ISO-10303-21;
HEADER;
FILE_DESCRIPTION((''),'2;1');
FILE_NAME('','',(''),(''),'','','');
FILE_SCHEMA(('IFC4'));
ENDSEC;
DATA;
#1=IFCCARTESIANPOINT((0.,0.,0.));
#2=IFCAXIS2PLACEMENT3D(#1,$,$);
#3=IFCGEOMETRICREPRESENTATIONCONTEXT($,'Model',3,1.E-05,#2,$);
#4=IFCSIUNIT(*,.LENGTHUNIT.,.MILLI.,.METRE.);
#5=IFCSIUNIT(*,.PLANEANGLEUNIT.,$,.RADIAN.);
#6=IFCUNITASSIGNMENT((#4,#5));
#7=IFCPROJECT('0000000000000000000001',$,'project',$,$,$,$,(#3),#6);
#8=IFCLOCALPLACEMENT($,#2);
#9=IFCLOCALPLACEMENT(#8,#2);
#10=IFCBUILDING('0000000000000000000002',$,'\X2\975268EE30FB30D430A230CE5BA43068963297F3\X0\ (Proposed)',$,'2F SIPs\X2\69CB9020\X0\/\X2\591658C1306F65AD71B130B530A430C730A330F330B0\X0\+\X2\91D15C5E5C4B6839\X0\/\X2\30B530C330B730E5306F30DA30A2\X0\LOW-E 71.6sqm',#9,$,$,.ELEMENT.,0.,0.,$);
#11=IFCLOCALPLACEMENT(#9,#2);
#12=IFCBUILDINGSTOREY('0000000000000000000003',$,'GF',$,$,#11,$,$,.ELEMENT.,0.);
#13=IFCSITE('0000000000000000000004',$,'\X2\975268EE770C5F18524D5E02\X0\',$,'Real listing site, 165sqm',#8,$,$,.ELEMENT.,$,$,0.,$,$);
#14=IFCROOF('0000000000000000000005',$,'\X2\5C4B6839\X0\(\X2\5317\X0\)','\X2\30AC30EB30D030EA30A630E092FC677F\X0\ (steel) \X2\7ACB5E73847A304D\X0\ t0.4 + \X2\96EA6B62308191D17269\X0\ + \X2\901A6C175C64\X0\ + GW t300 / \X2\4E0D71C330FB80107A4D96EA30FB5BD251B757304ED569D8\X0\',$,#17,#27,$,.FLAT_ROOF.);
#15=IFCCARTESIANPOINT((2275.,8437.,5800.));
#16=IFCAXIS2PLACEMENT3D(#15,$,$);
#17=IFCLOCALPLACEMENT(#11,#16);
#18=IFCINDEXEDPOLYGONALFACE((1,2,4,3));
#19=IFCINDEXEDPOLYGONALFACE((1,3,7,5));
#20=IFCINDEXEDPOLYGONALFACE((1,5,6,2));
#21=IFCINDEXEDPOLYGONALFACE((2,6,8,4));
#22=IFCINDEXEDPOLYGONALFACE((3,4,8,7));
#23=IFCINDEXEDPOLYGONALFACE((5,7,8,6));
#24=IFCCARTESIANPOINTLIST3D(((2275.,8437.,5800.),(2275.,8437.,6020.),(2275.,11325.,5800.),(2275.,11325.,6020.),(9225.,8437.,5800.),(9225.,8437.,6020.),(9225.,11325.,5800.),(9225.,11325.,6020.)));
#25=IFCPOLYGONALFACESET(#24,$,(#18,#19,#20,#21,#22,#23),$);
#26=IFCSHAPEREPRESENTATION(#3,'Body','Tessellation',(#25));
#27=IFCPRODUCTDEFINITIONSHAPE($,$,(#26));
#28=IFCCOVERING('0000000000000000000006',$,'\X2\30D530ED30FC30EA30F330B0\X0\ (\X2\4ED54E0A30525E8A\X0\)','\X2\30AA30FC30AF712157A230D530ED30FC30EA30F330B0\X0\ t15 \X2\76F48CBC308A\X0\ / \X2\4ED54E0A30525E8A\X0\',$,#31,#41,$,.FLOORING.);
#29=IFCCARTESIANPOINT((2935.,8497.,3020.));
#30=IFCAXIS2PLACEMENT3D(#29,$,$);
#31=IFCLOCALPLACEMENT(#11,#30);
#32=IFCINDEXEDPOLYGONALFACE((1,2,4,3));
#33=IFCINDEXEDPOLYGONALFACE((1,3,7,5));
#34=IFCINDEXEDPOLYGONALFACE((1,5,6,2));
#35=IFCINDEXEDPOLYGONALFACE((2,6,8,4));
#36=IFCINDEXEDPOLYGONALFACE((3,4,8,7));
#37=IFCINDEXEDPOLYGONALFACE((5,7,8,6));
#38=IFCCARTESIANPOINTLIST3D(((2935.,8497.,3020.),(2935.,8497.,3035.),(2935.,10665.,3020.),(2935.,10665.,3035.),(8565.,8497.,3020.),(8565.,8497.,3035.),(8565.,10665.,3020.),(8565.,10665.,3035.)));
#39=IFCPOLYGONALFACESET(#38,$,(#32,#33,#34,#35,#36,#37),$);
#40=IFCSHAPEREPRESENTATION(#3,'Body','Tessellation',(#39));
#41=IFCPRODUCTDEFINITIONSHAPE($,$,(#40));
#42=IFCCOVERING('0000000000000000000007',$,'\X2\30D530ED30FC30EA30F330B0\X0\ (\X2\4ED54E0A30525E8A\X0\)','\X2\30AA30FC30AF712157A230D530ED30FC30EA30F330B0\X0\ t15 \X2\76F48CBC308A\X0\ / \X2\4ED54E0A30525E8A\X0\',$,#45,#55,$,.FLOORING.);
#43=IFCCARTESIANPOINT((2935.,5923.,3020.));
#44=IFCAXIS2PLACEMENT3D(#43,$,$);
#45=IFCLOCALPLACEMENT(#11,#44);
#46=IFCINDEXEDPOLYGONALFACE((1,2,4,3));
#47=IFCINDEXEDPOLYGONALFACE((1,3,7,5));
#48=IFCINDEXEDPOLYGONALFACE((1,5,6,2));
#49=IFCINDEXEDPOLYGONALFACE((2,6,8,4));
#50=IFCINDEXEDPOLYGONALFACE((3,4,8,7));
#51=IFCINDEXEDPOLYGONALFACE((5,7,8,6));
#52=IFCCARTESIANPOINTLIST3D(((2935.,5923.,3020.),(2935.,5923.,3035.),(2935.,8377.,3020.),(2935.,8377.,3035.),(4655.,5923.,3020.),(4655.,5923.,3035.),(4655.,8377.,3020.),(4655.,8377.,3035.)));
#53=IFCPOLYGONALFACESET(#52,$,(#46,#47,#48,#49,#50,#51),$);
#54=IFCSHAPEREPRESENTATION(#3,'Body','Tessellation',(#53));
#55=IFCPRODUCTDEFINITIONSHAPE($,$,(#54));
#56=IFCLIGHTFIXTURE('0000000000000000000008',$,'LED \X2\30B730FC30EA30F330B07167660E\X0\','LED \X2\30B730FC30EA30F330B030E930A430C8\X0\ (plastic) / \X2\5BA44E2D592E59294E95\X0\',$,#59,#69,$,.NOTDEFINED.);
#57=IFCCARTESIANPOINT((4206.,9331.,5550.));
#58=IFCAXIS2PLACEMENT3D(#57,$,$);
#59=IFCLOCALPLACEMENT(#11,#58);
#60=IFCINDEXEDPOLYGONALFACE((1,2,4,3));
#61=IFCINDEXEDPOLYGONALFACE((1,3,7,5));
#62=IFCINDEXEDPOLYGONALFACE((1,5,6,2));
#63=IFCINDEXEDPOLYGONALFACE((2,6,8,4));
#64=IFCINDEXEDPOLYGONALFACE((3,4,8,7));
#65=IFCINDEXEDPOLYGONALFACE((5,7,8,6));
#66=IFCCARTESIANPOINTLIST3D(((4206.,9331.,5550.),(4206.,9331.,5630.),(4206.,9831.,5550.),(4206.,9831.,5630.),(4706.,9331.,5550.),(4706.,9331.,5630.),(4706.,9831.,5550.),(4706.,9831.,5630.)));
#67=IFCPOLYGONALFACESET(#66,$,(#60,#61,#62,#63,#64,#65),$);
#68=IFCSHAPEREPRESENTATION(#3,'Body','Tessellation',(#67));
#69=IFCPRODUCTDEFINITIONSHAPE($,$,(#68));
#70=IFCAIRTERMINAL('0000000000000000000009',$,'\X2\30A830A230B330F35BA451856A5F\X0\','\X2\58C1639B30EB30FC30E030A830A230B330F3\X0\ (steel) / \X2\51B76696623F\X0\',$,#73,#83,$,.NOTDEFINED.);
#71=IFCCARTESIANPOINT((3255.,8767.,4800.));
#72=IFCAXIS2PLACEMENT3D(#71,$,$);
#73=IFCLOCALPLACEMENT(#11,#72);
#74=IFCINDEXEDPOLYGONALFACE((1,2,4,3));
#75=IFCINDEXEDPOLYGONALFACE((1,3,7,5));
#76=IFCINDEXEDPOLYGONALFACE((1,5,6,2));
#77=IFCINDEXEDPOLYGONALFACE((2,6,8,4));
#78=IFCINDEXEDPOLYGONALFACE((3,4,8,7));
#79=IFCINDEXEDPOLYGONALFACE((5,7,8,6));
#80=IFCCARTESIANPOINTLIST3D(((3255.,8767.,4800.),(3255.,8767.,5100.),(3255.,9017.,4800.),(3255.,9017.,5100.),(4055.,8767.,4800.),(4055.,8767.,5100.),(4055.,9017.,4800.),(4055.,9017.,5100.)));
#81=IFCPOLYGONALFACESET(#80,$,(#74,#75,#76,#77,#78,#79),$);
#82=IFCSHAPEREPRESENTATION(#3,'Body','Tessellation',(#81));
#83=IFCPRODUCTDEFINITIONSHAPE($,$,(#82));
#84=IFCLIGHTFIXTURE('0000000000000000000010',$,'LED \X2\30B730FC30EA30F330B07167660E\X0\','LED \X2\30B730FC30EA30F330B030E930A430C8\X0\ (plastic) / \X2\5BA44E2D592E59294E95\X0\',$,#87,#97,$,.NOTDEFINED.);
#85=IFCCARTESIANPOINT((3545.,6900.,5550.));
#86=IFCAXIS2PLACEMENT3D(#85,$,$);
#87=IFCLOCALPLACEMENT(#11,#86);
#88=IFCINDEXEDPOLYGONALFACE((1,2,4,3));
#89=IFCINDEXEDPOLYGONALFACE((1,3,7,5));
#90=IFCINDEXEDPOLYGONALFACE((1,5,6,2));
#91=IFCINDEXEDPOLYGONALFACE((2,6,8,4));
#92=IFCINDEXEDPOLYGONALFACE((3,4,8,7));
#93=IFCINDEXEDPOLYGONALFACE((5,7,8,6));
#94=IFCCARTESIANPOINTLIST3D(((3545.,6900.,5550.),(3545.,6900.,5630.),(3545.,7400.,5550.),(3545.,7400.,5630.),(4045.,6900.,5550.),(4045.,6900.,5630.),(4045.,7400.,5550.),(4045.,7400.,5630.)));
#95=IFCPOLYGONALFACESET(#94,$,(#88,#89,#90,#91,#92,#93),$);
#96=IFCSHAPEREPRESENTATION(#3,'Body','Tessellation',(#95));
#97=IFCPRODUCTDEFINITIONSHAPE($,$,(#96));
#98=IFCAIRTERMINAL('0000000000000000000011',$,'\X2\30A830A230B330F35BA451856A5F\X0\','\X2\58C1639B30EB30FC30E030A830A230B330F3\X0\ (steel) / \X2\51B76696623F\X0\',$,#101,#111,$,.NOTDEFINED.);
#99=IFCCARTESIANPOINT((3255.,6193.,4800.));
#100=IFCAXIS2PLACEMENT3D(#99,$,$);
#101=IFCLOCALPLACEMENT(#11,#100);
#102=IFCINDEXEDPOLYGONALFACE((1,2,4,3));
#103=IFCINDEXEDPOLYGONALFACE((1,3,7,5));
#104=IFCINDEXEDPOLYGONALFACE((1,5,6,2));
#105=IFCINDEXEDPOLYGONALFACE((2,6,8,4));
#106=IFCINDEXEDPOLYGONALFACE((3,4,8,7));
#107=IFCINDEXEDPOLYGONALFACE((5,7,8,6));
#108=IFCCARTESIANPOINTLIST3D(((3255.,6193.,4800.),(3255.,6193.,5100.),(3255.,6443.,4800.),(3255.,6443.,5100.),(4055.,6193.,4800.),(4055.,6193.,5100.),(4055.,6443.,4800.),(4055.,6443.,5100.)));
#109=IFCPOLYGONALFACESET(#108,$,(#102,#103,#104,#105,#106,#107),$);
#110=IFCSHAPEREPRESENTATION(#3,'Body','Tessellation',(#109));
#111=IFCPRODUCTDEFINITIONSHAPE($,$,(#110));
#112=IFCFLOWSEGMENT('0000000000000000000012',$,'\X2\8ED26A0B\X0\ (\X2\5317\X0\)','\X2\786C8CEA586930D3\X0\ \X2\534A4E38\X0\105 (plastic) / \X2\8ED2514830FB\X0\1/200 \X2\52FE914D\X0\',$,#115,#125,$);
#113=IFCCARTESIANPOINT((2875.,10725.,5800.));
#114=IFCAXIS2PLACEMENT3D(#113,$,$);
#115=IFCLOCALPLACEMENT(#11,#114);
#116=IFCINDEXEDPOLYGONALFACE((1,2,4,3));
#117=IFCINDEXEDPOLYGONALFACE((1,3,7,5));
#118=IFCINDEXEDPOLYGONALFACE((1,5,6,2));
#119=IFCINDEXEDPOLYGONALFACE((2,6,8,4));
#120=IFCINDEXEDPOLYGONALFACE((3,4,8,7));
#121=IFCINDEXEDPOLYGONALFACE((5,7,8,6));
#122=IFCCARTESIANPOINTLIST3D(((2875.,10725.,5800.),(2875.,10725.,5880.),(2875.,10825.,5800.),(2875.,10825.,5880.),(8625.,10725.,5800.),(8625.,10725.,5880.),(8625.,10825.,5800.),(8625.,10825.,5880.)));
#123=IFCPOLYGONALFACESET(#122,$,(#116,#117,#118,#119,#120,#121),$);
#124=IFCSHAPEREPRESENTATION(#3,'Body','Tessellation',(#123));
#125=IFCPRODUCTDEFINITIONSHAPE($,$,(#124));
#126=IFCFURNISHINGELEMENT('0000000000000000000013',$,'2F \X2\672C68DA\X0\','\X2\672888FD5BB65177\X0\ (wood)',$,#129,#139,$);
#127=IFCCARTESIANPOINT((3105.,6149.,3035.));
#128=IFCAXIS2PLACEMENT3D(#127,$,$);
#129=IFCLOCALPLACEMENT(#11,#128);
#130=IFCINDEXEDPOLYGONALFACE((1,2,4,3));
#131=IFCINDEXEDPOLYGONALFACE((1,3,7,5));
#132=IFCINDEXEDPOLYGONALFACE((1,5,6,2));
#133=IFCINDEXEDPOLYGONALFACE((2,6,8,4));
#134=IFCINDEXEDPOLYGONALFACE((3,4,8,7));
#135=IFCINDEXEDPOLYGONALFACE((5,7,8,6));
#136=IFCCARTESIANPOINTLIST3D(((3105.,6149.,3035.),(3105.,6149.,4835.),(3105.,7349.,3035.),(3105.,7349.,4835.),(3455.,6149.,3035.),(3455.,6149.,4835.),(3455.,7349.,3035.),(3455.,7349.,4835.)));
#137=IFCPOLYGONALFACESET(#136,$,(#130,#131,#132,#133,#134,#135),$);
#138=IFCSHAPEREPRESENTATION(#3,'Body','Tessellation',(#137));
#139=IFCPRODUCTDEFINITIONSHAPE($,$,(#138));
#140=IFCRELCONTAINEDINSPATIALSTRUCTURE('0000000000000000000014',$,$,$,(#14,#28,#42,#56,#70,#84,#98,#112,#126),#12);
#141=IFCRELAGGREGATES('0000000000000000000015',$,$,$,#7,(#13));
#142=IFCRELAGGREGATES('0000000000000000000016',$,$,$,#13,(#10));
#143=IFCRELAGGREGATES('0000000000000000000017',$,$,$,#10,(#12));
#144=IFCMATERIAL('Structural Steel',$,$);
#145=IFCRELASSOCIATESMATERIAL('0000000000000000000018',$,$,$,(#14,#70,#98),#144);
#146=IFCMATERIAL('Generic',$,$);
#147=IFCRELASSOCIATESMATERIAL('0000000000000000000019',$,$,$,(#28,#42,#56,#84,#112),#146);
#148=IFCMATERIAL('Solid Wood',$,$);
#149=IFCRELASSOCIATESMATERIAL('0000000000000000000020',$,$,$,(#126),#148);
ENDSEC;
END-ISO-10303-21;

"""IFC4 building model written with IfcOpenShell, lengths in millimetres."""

from ifc_helpers import new_model, si_unit, frame, frame_2d, origin, place, context, project, spatial, rectangle, extrude, material, element, save


model = new_model("IFC4")

# Units and contexts
model_context = context("Model", 3, precision=1e-05, world=origin())
ifc_project = project(units=[si_unit("LENGTHUNIT", "METRE", prefix="MILLI"), si_unit("PLANEANGLEUNIT", "RADIAN")], contexts=[model_context])

# Site, building, storey
site_placement = place(None, origin())
site = spatial("IfcSite", under=ifc_project, at=site_placement, Name="青森県弘前市", ObjectType="Real listing site, 165sqm", CompositionType="ELEMENT", RefElevation=0.0)
building_placement = place(site_placement, origin())
building = spatial("IfcBuilding", under=site, at=building_placement, Name="青森・ピアノ室と防音 (Proposed)", ObjectType="2F SIPs構造/外壁は断熱サイディング+金属屋根/サッシュはペアLOW-E 71.6sqm", CompositionType="ELEMENT", ElevationOfRefHeight=0.0, ElevationOfTerrain=0.0)
storey_placement = place(building_placement, origin())
storey = spatial("IfcBuildingStorey", under=building, at=storey_placement, Name="GF", CompositionType="ELEMENT", Elevation=0.0)

# Shared definitions
ifc_material_1 = material(Name="Solid Wood")

# Roof
ifc_material_2 = material(Name="Structural Steel")
for number, where, name in (
    (1, (2275.0, 8437.0, 5800.0), "屋根(北)"),
):
    element("IfcRoof", number, at=place(storey_placement, frame(where)), inside=storey, material=ifc_material_2, Name=name, Description="ガルバリウム鋼板 (steel) 立平葺き t0.4 + 雪止め金物 + 通気層 + GW t300 / 不燃・耐積雪・寒冷地仕様", PredefinedType="FLAT_ROOF", context=model_context, shape_type="SweptSolid", body=[
        extrude(rectangle(XDim=6950.0, YDim=2888.0, at=frame_2d((3475.0, 1444.0))), frame((2275.0, 8437.0, 5800.0)), (0.0, 0.0, 1.0), 220.0),
    ])

# Coverings
ifc_material_3 = material(Name="Generic")
covering_1_placement = place(storey_placement, frame((2935.0, 8497.0, 3020.0)))
element("IfcCovering", 2, at=covering_1_placement, inside=storey, material=ifc_material_3, Name="フローリング (仕上げ床)", Description="オーク無垢フローリング t15 直貼り / 仕上げ床", PredefinedType="FLOORING", context=model_context, shape_type="SweptSolid", body=[
    extrude(rectangle(XDim=5630.0, YDim=2168.0, at=frame_2d((2815.0, 1084.0))), frame((2935.0, 8497.0, 3020.0)), (0.0, 0.0, 1.0), 15.0),
])
covering_2_placement = place(storey_placement, frame((2935.0, 5923.0, 3020.0)))
element("IfcCovering", 3, at=covering_2_placement, inside=storey, material=ifc_material_3, Name="フローリング (仕上げ床)", Description="オーク無垢フローリング t15 直貼り / 仕上げ床", PredefinedType="FLOORING", context=model_context, shape_type="SweptSolid", body=[
    extrude(rectangle(XDim=1720.0, YDim=2454.0, at=frame_2d((860.0, 1227.0))), frame((2935.0, 5923.0, 3020.0)), (0.0, 0.0, 1.0), 15.0),
])

# Light fixture
light_fixture_1_placement = place(storey_placement, frame((4206.0, 9331.0, 5550.0)))
element("IfcLightFixture", 4, at=light_fixture_1_placement, inside=storey, material=ifc_material_3, Name="LED シーリング照明", Description="LED シーリングライト (plastic) / 室中央天井", PredefinedType="NOTDEFINED", context=model_context, shape_type="SweptSolid", body=[
    extrude(rectangle(XDim=500.0, YDim=500.0, at=frame_2d((250.0, 250.0))), frame((4206.0, 9331.0, 5550.0)), (0.0, 0.0, 1.0), 80.0),
])

# Air terminal
air_terminal_1_placement = place(storey_placement, frame((3255.0, 8767.0, 4800.0)))
element("IfcAirTerminal", 5, at=air_terminal_1_placement, inside=storey, material=ifc_material_2, Name="エアコン室内機", Description="壁掛ルームエアコン (steel) / 冷暖房", PredefinedType="NOTDEFINED", context=model_context, shape_type="SweptSolid", body=[
    extrude(rectangle(XDim=800.0, YDim=250.0, at=frame_2d((400.0, 125.0))), frame((3255.0, 8767.0, 4800.0)), (0.0, 0.0, 1.0), 300.0),
])

# Light fixture
light_fixture_2_placement = place(storey_placement, frame((3545.0, 6900.0, 5550.0)))
element("IfcLightFixture", 6, at=light_fixture_2_placement, inside=storey, material=ifc_material_3, Name="LED シーリング照明", Description="LED シーリングライト (plastic) / 室中央天井", PredefinedType="NOTDEFINED", context=model_context, shape_type="SweptSolid", body=[
    extrude(rectangle(XDim=500.0, YDim=500.0, at=frame_2d((250.0, 250.0))), frame((3545.0, 6900.0, 5550.0)), (0.0, 0.0, 1.0), 80.0),
])

# Air terminal
air_terminal_2_placement = place(storey_placement, frame((3255.0, 6193.0, 4800.0)))
element("IfcAirTerminal", 7, at=air_terminal_2_placement, inside=storey, material=ifc_material_2, Name="エアコン室内機", Description="壁掛ルームエアコン (steel) / 冷暖房", PredefinedType="NOTDEFINED", context=model_context, shape_type="SweptSolid", body=[
    extrude(rectangle(XDim=800.0, YDim=250.0, at=frame_2d((400.0, 125.0))), frame((3255.0, 6193.0, 4800.0)), (0.0, 0.0, 1.0), 300.0),
])

# Flow segment
flow_segment_placement = place(storey_placement, frame((2875.0, 10725.0, 5800.0)))
element("IfcFlowSegment", 8, at=flow_segment_placement, inside=storey, material=ifc_material_3, Name="軒樋 (北)", Description="硬質塩ビ 半丸105 (plastic) / 軒先・1/200 勾配", context=model_context, shape_type="SweptSolid", body=[
    extrude(rectangle(XDim=5750.0, YDim=100.0, at=frame_2d((2875.0, 50.0))), frame((2875.0, 10725.0, 5800.0)), (0.0, 0.0, 1.0), 80.0),
])

# Furnishing element
furnishing_placement = place(storey_placement, frame((3105.0, 6149.0, 3035.0)))
element("IfcFurnishingElement", 9, at=furnishing_placement, inside=storey, material=ifc_material_1, Name="2F 本棚", Description="木製家具 (wood)", context=model_context, shape_type="SweptSolid", body=[
    extrude(rectangle(XDim=350.0, YDim=1200.0, at=frame_2d((175.0, 600.0))), frame((3105.0, 6149.0, 3035.0)), (0.0, 0.0, 1.0), 1800.0),
])

save(model, "model.ifc")
